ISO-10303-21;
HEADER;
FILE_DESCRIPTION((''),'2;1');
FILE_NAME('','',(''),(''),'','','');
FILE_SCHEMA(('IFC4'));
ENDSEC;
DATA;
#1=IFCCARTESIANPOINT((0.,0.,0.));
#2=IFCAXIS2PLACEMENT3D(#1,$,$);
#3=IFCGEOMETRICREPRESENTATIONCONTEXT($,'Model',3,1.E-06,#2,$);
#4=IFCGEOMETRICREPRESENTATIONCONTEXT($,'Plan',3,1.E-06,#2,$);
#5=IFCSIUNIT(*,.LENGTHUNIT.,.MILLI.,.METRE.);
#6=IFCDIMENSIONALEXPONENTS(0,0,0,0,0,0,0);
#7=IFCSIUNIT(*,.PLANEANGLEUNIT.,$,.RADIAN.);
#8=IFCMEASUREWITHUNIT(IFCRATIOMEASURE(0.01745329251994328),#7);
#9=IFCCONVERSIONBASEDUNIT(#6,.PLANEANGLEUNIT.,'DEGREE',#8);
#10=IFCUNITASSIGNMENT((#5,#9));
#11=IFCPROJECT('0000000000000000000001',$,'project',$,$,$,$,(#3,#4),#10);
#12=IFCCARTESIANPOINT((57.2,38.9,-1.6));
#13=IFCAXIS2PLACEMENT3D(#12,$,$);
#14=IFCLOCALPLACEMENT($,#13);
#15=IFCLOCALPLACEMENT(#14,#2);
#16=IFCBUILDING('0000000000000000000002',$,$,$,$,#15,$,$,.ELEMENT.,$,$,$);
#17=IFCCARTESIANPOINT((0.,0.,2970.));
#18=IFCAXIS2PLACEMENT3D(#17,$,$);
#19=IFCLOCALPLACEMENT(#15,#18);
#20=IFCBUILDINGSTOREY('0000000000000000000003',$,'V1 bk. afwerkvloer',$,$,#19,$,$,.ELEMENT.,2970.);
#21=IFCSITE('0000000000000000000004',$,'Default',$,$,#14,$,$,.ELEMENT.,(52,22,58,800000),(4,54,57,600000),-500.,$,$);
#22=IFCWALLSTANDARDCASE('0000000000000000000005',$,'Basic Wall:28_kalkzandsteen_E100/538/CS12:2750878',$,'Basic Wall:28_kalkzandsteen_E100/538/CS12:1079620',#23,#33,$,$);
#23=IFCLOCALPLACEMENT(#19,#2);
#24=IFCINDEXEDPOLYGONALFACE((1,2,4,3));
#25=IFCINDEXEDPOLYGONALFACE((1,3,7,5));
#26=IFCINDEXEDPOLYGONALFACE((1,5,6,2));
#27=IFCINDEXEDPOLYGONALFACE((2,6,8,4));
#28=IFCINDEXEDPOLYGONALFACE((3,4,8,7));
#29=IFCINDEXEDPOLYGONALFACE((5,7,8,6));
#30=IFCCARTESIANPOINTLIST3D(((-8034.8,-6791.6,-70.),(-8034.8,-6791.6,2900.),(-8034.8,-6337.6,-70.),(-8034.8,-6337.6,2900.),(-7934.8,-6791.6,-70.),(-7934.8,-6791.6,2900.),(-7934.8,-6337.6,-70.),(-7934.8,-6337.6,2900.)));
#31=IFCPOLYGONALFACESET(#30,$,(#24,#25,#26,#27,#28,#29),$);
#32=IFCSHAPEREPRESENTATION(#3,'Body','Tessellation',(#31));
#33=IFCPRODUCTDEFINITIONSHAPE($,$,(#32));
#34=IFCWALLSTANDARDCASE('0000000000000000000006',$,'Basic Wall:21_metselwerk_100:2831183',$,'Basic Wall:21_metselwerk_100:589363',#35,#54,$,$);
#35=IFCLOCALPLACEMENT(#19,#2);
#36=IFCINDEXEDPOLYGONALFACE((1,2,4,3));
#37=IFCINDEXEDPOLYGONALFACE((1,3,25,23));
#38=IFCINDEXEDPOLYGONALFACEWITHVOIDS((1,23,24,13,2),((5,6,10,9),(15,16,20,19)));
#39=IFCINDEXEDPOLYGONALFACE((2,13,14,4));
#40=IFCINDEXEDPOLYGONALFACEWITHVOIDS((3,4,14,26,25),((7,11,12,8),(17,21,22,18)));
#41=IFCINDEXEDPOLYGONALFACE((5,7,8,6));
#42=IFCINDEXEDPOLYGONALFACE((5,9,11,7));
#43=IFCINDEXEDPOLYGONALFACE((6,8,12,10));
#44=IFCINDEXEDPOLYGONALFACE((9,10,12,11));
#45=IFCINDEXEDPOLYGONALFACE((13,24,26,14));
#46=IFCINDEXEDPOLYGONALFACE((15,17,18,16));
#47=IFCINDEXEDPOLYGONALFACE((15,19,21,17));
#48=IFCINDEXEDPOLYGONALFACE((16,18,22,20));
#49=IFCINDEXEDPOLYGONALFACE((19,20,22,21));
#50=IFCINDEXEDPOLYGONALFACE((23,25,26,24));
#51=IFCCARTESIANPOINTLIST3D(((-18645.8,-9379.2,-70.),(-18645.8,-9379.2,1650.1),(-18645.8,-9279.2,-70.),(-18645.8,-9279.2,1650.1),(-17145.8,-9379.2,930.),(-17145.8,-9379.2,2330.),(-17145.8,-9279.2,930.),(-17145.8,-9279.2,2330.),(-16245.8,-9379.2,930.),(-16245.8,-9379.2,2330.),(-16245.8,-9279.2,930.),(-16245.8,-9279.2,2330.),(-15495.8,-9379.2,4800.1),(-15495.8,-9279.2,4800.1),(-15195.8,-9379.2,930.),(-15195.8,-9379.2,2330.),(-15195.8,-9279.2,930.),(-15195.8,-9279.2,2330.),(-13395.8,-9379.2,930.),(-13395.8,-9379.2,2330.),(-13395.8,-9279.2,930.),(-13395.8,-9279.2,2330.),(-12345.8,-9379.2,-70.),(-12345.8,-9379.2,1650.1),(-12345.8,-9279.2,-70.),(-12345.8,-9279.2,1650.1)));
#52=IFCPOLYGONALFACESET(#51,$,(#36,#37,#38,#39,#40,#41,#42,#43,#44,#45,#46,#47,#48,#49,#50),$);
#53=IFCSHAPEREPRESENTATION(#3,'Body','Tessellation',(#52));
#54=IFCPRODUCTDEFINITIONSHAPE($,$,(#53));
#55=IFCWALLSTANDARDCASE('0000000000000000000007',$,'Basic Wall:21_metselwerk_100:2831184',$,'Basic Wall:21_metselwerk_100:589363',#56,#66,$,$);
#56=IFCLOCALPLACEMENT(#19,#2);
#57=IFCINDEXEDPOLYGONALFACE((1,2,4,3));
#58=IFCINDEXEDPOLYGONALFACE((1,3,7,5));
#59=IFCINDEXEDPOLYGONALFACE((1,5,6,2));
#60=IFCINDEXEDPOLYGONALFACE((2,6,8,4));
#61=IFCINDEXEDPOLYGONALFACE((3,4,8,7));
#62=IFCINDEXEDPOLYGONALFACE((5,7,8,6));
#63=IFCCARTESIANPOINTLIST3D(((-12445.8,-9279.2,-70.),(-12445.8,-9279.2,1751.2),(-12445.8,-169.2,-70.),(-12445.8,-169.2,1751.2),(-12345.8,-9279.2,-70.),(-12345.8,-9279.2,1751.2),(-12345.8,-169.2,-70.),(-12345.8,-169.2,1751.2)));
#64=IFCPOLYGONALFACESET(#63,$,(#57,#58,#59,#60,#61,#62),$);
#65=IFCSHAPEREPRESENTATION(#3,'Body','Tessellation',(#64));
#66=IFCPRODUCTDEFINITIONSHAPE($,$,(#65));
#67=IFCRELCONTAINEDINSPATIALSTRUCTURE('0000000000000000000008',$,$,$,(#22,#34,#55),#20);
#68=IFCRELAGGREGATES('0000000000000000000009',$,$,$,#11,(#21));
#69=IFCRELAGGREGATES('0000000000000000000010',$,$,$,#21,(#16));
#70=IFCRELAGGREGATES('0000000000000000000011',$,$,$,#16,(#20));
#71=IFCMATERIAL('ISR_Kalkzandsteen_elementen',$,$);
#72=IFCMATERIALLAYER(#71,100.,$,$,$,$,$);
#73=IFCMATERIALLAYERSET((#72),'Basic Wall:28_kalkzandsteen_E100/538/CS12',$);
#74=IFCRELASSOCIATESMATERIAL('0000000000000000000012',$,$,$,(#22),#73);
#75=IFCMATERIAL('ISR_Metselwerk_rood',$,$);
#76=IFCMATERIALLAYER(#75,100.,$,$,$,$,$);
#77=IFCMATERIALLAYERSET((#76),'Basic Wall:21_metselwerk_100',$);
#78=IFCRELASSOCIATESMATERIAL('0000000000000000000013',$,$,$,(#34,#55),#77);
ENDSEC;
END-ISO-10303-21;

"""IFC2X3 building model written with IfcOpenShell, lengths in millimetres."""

from ifc_helpers import new_model, entity, si_unit, converted_unit, frame, frame_2d, origin, origin_2d_with_axis, place, context, project, spatial, polyline, rectangle, extrude, clip, bounded_halfspace, material, layer, layer_set, layer_usage, element, save


model = new_model("IFC2X3")

# Units and contexts
model_context = context("Model", 3, precision=1e-06, world=origin())
plan_context = context("Plan", 3, precision=1e-06, world=origin())
ifc_project = project(units=[si_unit("LENGTHUNIT", "METRE", prefix="MILLI"), converted_unit("PLANEANGLEUNIT", "DEGREE", entity("IfcRatioMeasure", 0.01745329251994328), si_unit("PLANEANGLEUNIT", "RADIAN"), dimensions=[0, 0, 0, 0, 0, 0, 0])], contexts=[model_context, plan_context])

# Site, building, storey
site_placement = place(None, frame((57.2, 38.9, -1.6)))
site = spatial("IfcSite", under=ifc_project, at=site_placement, Name="Default", CompositionType="ELEMENT", RefLatitude=(52, 22, 58, 800000), RefLongitude=(4, 54, 57, 600000), RefElevation=-500.0)
building_placement = place(site_placement, origin())
building = spatial("IfcBuilding", under=site, at=building_placement, CompositionType="ELEMENT")
storey_placement = place(building_placement, frame((0.0, 0.0, 2970.0)))
storey = spatial("IfcBuildingStorey", under=building, at=storey_placement, Name="V1 bk. afwerkvloer", CompositionType="ELEMENT", Elevation=2970.0)

# Shared definitions
ifc_material_1 = material(Name="ISR_Kalkzandsteen_elementen")
ifc_layer_1 = layer(ifc_material_1, 100.0)
ifc_layer_set_1 = layer_set([ifc_layer_1], Name="Basic Wall:28_kalkzandsteen_E100/538/CS12")

# Shared definitions
ifc_material_2 = material(Name="ISR_Metselwerk_rood")
ifc_layer_2 = layer(ifc_material_2, 100.0)
ifc_layer_set_2 = layer_set([ifc_layer_2], Name="Basic Wall:21_metselwerk_100")

# Wall
ifc_layer_usage_1 = layer_usage(ifc_layer_set_1, "AXIS2", "NEGATIVE", 50.0)
wall_1_placement = place(storey_placement, frame((-7984.8, -6791.6, -70.0), z_axis=(0.0, 0.0, 1.0), x_axis=(0.0, 1.0, 0.0)))
element("IfcWallStandardCase", 1, at=wall_1_placement, inside=storey, material=ifc_layer_usage_1, Name="Basic Wall:28_kalkzandsteen_E100/538/CS12:2750878", ObjectType="Basic Wall:28_kalkzandsteen_E100/538/CS12:1079620", context=model_context, shape_type="SweptSolid", body=[
    extrude(rectangle(XDim=454.0, YDim=100.0, at=frame_2d((227.0, 0.0), x_axis=(-1.0, 0.0))), origin(), (0.0, 0.0, 1.0), 2970.0),
])

# Wall, openings
ifc_layer_usage_2 = layer_usage(ifc_layer_set_2, "AXIS2", "POSITIVE", -50.0)
wall_2_placement = place(storey_placement, frame((-12345.8, -9329.2, -70.0), z_axis=(0.0, 0.0, 1.0), x_axis=(-1.0, 0.0, 0.0)))
wall_2 = element("IfcWallStandardCase", 2, at=wall_2_placement, inside=storey, material=ifc_layer_usage_2, Name="Basic Wall:21_metselwerk_100:2831183", ObjectType="Basic Wall:21_metselwerk_100:589363", context=model_context, shape_type="Clipping", body=[
    clip(clip(extrude(rectangle(XDim=6300.0, YDim=100.0, at=frame_2d((3150.0, 0.0), x_axis=(-1.0, 0.0))), origin(), (0.0, 0.0, 1.0), 4870.1), bounded_halfspace(frame((0.0, 50.0, 1720.1), z_axis=(-0.707107, 0.0, 0.707107), x_axis=(0.0, -1.0, 0.0)), False, frame((0.0, 50.0, 1720.1)), polyline([(0.0, 0.0), (0.0, -100.0), (3150.0, -100.0), (3150.0, 0.0), (0.0, 0.0)]))), bounded_halfspace(frame((3150.0, -50.0, 4870.1), z_axis=(0.707107, 0.0, 0.707107), x_axis=(0.0, 1.0, 0.0)), False, frame((3150.0, -50.0, 4870.1)), polyline([(0.0, 0.0), (3150.0, 0.0), (3150.0, 100.0), (0.0, 100.0), (0.0, 0.0)]))),
])
opening_1_placement = place(wall_2_placement, origin())
element("IfcOpeningElement", 3, at=opening_1_placement, cuts=wall_2, ObjectType="Opening", context=model_context, shape_type="SweptSolid", body=[
    extrude(rectangle(XDim=1400.0, YDim=1800.0, at=origin_2d_with_axis()), frame((1950.0, -202.4, 1700.0), z_axis=(0.0, 1.0, 0.0), x_axis=(0.0, 0.0, 1.0)), (0.0, 0.0, 1.0), 404.8),
])
opening_2_placement = place(wall_2_placement, origin())
element("IfcOpeningElement", 4, at=opening_2_placement, cuts=wall_2, ObjectType="Opening", context=model_context, shape_type="SweptSolid", body=[
    extrude(rectangle(XDim=1400.0, YDim=900.0, at=origin_2d_with_axis()), frame((4350.0, -202.4, 1700.0), z_axis=(0.0, 1.0, 0.0), x_axis=(0.0, 0.0, 1.0)), (0.0, 0.0, 1.0), 404.8),
])

# Wall
ifc_layer_usage_3 = layer_usage(ifc_layer_set_2, "AXIS2", "POSITIVE", -50.0)
wall_3_placement = place(storey_placement, frame((-12395.8, -9279.2, -70.0), z_axis=(0.0, 0.0, 1.0), x_axis=(0.0, 1.0, 0.0)))
element("IfcWallStandardCase", 5, at=wall_3_placement, inside=storey, material=ifc_layer_usage_3, Name="Basic Wall:21_metselwerk_100:2831184", ObjectType="Basic Wall:21_metselwerk_100:589363", context=model_context, shape_type="SweptSolid", body=[
    extrude(rectangle(XDim=9110.0, YDim=100.0, at=frame_2d((4555.0, 0.0), x_axis=(-1.0, 0.0))), origin(), (0.0, 0.0, 1.0), 1821.2),
])

save(model, "model.ifc")
